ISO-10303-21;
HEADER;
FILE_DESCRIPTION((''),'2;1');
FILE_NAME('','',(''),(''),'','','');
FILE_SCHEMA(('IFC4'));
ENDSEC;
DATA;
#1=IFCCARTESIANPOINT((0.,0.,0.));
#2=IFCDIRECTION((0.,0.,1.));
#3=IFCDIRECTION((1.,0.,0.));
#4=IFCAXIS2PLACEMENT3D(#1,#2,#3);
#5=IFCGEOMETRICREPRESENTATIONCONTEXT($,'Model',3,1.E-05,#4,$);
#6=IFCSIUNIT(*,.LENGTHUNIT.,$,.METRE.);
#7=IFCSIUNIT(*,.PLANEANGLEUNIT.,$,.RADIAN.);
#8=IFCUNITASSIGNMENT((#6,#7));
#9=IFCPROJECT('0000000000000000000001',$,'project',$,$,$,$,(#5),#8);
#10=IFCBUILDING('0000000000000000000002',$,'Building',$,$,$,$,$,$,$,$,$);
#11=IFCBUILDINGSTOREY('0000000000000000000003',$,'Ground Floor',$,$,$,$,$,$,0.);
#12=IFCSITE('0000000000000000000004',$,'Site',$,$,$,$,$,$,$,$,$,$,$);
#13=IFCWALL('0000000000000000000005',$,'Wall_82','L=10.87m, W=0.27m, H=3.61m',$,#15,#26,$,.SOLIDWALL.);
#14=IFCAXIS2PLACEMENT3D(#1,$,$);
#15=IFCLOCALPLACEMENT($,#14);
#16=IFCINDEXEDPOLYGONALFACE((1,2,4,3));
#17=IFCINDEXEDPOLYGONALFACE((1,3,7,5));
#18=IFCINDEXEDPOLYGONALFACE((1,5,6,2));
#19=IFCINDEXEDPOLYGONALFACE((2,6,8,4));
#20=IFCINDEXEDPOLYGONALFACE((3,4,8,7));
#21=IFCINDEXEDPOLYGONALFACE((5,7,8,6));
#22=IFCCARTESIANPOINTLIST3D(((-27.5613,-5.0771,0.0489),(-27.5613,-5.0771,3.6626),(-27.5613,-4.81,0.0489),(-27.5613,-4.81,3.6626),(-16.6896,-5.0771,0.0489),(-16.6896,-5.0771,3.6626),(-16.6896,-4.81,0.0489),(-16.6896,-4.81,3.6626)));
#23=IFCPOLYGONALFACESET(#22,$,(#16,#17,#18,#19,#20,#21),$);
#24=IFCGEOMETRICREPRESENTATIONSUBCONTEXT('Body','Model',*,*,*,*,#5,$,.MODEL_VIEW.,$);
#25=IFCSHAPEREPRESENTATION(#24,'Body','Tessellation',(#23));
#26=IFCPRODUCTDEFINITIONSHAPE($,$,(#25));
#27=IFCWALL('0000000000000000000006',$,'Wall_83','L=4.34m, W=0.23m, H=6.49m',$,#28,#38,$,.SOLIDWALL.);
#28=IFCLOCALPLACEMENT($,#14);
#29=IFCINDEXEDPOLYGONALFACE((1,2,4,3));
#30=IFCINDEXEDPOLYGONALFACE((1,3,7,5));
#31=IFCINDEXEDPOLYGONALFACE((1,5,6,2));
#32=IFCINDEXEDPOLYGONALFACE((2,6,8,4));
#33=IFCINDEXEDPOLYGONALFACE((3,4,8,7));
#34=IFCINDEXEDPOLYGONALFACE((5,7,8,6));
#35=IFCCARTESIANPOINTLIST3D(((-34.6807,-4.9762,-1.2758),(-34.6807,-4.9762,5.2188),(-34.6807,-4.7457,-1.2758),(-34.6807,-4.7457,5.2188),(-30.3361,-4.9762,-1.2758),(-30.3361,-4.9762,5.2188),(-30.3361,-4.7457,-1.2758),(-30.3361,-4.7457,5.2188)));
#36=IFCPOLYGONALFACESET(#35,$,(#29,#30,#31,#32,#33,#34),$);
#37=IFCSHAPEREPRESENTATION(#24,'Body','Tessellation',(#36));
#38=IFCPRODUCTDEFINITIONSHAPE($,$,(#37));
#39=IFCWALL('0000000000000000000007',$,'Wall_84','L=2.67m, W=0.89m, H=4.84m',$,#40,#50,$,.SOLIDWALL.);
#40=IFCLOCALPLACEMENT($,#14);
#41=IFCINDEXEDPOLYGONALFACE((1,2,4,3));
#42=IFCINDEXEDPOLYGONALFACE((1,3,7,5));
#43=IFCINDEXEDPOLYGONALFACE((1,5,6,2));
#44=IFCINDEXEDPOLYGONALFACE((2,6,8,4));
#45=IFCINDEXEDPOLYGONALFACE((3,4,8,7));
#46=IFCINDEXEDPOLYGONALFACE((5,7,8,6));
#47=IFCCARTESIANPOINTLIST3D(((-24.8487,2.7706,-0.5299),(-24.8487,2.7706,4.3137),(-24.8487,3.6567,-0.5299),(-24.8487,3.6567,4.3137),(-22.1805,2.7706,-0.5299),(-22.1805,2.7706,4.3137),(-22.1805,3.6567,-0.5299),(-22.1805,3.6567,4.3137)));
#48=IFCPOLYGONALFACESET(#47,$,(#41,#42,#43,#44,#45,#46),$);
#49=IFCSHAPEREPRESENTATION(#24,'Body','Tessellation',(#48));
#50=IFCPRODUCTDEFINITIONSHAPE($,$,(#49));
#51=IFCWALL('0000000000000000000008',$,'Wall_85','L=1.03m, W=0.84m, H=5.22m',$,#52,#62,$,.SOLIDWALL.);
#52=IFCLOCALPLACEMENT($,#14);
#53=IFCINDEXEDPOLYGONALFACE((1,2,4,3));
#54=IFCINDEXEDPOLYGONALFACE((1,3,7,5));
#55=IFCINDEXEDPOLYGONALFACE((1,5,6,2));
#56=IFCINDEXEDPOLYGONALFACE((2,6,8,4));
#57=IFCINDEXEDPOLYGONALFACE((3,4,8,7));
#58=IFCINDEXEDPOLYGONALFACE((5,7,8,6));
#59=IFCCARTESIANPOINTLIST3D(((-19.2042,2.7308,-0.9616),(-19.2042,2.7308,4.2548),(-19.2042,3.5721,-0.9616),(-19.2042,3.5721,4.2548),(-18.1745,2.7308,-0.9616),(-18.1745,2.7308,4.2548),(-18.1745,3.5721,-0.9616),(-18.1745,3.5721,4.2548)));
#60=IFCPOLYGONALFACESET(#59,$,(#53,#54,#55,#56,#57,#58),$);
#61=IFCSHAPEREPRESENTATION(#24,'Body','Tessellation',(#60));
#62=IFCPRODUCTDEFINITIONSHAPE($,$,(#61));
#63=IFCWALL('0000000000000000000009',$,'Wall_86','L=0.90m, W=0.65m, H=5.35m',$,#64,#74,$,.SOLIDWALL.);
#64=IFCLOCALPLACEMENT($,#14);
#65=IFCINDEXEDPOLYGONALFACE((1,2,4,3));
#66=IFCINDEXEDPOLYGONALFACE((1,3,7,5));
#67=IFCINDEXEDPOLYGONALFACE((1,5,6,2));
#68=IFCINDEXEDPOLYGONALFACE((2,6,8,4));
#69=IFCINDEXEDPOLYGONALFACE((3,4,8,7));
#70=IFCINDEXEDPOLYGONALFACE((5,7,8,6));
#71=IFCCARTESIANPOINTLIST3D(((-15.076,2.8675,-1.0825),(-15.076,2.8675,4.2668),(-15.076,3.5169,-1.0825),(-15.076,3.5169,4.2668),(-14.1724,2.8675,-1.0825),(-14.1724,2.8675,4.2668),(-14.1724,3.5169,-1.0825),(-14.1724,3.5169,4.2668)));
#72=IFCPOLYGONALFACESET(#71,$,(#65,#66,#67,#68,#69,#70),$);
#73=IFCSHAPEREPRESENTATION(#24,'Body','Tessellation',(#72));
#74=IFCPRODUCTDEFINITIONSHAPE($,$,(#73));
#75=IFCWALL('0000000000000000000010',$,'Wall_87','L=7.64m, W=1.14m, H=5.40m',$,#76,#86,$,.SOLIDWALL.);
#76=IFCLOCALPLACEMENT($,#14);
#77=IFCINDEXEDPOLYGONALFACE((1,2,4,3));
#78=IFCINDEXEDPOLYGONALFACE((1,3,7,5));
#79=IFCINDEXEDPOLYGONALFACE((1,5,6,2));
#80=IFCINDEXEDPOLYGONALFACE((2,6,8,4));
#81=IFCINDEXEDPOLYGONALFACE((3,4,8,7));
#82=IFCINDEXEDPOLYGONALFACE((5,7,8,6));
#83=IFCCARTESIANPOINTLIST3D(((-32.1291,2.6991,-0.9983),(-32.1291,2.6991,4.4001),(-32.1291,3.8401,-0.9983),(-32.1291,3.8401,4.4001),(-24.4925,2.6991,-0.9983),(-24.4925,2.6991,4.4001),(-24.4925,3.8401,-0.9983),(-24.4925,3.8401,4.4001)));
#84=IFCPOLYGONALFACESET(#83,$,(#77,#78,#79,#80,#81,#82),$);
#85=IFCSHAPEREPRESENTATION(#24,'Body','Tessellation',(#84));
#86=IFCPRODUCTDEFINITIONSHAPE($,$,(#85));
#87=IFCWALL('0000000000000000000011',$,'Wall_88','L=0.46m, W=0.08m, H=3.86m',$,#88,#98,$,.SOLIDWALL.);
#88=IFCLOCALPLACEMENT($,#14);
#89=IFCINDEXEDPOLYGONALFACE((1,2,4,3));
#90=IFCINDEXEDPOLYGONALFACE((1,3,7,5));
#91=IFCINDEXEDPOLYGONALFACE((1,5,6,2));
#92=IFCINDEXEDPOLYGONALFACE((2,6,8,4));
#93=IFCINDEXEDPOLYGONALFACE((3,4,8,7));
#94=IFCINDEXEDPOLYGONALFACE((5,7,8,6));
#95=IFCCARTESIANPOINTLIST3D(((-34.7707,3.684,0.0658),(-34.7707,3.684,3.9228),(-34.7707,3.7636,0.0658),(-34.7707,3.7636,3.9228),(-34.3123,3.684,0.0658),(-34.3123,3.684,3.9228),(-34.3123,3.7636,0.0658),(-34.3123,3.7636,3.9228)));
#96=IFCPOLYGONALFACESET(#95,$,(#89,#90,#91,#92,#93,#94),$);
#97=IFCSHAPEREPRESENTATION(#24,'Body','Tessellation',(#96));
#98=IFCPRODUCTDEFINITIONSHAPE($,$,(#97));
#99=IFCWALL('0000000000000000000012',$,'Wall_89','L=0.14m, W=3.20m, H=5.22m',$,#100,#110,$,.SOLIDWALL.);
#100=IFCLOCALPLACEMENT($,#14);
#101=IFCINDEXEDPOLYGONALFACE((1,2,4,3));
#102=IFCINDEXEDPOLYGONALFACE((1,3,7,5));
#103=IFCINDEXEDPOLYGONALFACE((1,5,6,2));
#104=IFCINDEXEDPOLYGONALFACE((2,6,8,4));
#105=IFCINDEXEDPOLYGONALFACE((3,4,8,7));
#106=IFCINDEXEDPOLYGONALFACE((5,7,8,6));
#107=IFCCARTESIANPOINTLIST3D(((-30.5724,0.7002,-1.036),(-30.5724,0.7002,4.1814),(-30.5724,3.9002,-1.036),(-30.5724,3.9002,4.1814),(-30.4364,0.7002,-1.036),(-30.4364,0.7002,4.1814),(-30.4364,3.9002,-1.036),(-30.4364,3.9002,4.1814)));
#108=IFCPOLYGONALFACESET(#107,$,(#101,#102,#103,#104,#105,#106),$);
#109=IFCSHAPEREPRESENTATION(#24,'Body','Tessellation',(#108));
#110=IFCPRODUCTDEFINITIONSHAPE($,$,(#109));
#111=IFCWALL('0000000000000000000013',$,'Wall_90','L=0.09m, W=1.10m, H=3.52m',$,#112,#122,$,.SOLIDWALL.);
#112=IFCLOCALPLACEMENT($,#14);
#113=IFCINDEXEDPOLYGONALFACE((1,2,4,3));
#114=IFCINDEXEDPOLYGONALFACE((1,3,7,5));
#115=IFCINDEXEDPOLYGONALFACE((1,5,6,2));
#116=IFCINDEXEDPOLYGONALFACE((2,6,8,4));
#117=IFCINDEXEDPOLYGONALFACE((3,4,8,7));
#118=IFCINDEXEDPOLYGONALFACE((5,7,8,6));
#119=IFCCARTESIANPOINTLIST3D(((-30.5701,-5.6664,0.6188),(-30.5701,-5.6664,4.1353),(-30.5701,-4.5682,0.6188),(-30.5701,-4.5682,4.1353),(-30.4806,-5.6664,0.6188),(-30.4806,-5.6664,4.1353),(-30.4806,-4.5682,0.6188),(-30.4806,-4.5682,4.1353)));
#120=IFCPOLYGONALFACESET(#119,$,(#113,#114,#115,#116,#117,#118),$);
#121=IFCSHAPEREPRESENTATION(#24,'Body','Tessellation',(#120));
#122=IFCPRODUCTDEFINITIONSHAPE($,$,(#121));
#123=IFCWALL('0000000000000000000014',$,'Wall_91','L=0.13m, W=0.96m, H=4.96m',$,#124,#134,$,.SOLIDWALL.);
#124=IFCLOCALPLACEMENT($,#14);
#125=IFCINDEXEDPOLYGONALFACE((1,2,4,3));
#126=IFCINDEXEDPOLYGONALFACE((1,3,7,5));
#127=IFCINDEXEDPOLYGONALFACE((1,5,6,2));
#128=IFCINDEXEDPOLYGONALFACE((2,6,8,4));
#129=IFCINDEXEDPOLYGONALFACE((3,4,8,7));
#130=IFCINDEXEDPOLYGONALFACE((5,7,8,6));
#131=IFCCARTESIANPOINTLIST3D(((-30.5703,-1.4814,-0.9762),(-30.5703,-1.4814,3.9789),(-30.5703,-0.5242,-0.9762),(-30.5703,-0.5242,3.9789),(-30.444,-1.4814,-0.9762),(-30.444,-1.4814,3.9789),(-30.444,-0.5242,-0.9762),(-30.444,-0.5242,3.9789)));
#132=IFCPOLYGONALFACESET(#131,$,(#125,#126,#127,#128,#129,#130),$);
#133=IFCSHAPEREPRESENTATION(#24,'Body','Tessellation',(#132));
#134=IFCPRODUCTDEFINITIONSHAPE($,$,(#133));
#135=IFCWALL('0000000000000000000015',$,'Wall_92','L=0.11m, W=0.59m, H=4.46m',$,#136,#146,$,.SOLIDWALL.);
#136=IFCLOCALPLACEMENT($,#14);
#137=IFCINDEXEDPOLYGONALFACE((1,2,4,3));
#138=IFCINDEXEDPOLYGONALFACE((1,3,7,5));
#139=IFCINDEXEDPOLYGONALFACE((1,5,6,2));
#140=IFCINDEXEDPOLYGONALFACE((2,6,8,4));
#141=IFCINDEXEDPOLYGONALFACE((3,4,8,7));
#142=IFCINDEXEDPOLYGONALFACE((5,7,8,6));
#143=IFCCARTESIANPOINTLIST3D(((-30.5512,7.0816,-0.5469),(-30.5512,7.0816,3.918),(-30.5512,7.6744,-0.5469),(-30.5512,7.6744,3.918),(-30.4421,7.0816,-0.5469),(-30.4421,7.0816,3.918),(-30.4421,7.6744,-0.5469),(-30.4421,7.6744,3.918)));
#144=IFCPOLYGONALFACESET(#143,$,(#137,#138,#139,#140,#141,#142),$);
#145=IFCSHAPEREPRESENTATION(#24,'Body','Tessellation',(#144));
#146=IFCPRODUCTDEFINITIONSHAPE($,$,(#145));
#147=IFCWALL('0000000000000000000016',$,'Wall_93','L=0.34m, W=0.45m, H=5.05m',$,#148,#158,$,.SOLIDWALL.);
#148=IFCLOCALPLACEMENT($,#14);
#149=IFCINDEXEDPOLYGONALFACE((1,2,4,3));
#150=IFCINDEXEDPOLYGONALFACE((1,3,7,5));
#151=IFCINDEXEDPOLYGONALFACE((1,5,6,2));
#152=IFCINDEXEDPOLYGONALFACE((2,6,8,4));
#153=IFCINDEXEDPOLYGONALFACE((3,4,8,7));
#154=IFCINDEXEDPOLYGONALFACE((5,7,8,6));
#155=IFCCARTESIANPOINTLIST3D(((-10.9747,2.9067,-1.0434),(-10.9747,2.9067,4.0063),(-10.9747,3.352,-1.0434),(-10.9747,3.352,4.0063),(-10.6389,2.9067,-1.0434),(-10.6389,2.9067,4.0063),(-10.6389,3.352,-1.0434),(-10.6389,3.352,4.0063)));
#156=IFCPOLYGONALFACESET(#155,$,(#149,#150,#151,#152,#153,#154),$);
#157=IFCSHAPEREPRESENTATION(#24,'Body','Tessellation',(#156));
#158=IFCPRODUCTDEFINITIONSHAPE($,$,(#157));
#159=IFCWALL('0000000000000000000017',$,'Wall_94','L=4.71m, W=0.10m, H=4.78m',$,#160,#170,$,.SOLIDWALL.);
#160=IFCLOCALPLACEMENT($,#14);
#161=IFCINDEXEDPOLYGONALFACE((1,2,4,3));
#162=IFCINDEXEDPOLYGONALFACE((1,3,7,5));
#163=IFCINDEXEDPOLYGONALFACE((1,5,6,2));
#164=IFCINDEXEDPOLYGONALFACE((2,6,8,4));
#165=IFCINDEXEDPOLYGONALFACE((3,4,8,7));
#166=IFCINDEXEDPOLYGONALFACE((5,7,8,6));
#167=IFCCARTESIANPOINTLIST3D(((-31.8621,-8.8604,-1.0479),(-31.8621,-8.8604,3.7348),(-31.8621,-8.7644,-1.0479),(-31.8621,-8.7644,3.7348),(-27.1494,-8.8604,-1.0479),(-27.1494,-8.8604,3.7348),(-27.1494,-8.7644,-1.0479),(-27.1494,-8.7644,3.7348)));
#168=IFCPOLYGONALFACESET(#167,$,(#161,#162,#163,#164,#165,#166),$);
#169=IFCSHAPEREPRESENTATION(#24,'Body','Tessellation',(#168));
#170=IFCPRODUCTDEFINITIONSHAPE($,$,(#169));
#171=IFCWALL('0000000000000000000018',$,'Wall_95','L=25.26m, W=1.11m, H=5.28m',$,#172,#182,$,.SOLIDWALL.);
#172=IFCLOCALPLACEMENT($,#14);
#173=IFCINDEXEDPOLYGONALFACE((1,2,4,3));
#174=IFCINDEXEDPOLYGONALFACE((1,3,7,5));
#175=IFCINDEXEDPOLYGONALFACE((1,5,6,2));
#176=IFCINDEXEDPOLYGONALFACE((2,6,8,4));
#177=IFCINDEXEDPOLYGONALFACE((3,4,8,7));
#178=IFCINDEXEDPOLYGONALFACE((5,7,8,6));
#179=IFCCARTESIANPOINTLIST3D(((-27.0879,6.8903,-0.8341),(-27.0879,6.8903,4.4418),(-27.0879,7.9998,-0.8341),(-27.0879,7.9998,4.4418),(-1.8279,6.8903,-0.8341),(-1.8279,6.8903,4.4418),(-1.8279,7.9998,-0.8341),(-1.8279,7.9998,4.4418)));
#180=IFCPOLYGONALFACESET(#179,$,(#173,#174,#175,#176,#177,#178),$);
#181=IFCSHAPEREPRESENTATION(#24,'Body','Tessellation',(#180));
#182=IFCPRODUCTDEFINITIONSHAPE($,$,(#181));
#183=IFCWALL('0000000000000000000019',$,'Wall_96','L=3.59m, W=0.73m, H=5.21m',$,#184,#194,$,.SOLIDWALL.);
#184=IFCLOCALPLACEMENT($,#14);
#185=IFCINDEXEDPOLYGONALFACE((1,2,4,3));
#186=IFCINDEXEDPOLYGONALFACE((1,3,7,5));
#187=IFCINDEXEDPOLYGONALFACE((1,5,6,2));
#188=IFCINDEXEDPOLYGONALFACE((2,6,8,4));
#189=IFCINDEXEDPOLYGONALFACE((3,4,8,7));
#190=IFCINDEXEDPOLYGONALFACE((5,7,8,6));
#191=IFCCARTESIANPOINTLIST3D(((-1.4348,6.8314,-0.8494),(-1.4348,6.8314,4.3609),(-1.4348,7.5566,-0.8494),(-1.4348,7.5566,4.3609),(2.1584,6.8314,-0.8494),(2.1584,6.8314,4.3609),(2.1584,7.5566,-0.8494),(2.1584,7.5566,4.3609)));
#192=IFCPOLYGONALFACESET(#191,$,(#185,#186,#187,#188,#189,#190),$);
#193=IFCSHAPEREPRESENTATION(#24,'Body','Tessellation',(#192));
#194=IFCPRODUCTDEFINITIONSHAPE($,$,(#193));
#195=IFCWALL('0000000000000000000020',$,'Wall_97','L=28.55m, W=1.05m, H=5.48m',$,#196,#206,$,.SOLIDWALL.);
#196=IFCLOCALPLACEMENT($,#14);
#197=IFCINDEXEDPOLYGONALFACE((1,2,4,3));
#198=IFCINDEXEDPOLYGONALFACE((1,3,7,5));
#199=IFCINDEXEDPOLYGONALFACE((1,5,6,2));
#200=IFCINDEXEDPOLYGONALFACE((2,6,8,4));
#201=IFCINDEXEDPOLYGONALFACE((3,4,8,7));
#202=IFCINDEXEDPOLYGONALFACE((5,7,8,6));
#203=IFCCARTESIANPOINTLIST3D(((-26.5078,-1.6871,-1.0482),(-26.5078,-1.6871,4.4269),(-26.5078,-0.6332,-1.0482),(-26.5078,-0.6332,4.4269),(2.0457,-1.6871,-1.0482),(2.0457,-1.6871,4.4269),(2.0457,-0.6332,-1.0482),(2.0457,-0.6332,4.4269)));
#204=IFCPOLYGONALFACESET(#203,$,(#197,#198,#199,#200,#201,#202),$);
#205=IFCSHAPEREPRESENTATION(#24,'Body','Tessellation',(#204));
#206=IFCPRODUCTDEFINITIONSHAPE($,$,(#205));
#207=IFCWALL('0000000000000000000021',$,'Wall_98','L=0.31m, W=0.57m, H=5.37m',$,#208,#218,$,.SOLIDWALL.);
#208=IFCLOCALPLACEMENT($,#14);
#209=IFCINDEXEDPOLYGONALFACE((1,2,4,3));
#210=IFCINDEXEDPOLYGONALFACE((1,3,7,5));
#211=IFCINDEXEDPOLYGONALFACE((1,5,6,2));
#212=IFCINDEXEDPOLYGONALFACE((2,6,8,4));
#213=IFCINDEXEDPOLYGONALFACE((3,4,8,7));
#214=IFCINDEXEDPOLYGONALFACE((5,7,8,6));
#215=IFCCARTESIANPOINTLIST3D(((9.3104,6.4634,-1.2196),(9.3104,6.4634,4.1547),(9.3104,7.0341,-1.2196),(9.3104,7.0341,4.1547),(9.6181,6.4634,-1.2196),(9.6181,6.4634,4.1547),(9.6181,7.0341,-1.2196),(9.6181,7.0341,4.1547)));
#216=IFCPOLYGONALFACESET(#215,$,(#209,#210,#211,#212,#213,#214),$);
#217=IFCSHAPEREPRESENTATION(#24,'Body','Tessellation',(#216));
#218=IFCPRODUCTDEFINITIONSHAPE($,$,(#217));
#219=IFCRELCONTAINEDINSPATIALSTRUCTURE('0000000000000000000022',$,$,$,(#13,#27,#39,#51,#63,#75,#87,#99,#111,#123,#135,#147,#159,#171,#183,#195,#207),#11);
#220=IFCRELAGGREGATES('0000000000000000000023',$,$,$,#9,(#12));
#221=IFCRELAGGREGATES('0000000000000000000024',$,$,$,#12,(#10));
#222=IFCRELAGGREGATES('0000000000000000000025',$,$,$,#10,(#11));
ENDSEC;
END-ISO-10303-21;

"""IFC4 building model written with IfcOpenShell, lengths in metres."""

from ifc_helpers import new_model, si_unit, frame, origin_with_axes, origin_2d, context, subcontext, project, spatial, rectangle, extrude, element, save


model = new_model("IFC4")

# Units and contexts
model_context = context("Model", 3, precision=1e-05, world=origin_with_axes())
body_context = subcontext(model_context, "Body", "Model", "MODEL_VIEW")
ifc_project = project(units=[si_unit("LENGTHUNIT", "METRE"), si_unit("PLANEANGLEUNIT", "RADIAN")], contexts=[model_context])

# Site, building, storey
site = spatial("IfcSite", under=ifc_project, Name="Site")
building = spatial("IfcBuilding", under=site, Name="Building")
storey = spatial("IfcBuildingStorey", under=building, Name="Ground Floor", Elevation=0.0)

# Walls
element("IfcWall", 1, inside=storey, Name="Wall_82", Description="L=10.87m, W=0.27m, H=3.61m", PredefinedType="SOLIDWALL", context=body_context, shape_type="SweptSolid", body=[
    extrude(rectangle(XDim=10.8717, YDim=0.267, at=origin_2d()), frame((-22.1254, -4.9436, 0.0489), z_axis=(0.0, 0.0, 1.0), x_axis=(1.0, 0.0, 0.0)), (0.0, 0.0, 1.0), 3.6137),
])
element("IfcWall", 2, inside=storey, Name="Wall_83", Description="L=4.34m, W=0.23m, H=6.49m", PredefinedType="SOLIDWALL", context=body_context, shape_type="SweptSolid", body=[
    extrude(rectangle(XDim=4.3446, YDim=0.2305, at=origin_2d()), frame((-32.5084, -4.861, -1.2758), z_axis=(0.0, 0.0, 1.0), x_axis=(1.0, 0.0, 0.0)), (0.0, 0.0, 1.0), 6.4946),
])
element("IfcWall", 3, inside=storey, Name="Wall_84", Description="L=2.67m, W=0.89m, H=4.84m", PredefinedType="SOLIDWALL", context=body_context, shape_type="SweptSolid", body=[
    extrude(rectangle(XDim=2.6682, YDim=0.8861, at=origin_2d()), frame((-23.5146, 3.2136, -0.5299), z_axis=(0.0, 0.0, 1.0), x_axis=(1.0, 0.0, 0.0)), (0.0, 0.0, 1.0), 4.8436),
])
element("IfcWall", 4, inside=storey, Name="Wall_85", Description="L=1.03m, W=0.84m, H=5.22m", PredefinedType="SOLIDWALL", context=body_context, shape_type="SweptSolid", body=[
    extrude(rectangle(XDim=1.0297, YDim=0.8412, at=origin_2d()), frame((-18.6894, 3.1514, -0.9616), z_axis=(0.0, 0.0, 1.0), x_axis=(1.0, 0.0, 0.0)), (0.0, 0.0, 1.0), 5.2164),
])
element("IfcWall", 5, inside=storey, Name="Wall_86", Description="L=0.90m, W=0.65m, H=5.35m", PredefinedType="SOLIDWALL", context=body_context, shape_type="SweptSolid", body=[
    extrude(rectangle(XDim=0.9035, YDim=0.6494, at=origin_2d()), frame((-14.6242, 3.1922, -1.0825), z_axis=(0.0, 0.0, 1.0), x_axis=(1.0, 0.0, 0.0)), (0.0, 0.0, 1.0), 5.3493),
])
element("IfcWall", 6, inside=storey, Name="Wall_87", Description="L=7.64m, W=1.14m, H=5.40m", PredefinedType="SOLIDWALL", context=body_context, shape_type="SweptSolid", body=[
    extrude(rectangle(XDim=7.6367, YDim=1.1411, at=origin_2d()), frame((-28.3108, 3.2696, -0.9983), z_axis=(0.0, 0.0, 1.0), x_axis=(1.0, 0.0, 0.0)), (0.0, 0.0, 1.0), 5.3984),
])
element("IfcWall", 7, inside=storey, Name="Wall_88", Description="L=0.46m, W=0.08m, H=3.86m", PredefinedType="SOLIDWALL", context=body_context, shape_type="SweptSolid", body=[
    extrude(rectangle(XDim=0.4584, YDim=0.0796, at=origin_2d()), frame((-34.5415, 3.7238, 0.0658), z_axis=(0.0, 0.0, 1.0), x_axis=(1.0, 0.0, 0.0)), (0.0, 0.0, 1.0), 3.857),
])
element("IfcWall", 8, inside=storey, Name="Wall_89", Description="L=0.14m, W=3.20m, H=5.22m", PredefinedType="SOLIDWALL", context=body_context, shape_type="SweptSolid", body=[
    extrude(rectangle(XDim=0.136, YDim=3.2, at=origin_2d()), frame((-30.5044, 2.3002, -1.036), z_axis=(0.0, 0.0, 1.0), x_axis=(1.0, 0.0, 0.0)), (0.0, 0.0, 1.0), 5.2174),
])
element("IfcWall", 9, inside=storey, Name="Wall_90", Description="L=0.09m, W=1.10m, H=3.52m", PredefinedType="SOLIDWALL", context=body_context, shape_type="SweptSolid", body=[
    extrude(rectangle(XDim=0.0895, YDim=1.0983, at=origin_2d()), frame((-30.5254, -5.1173, 0.6188), z_axis=(0.0, 0.0, 1.0), x_axis=(1.0, 0.0, 0.0)), (0.0, 0.0, 1.0), 3.5166),
])
element("IfcWall", 10, inside=storey, Name="Wall_91", Description="L=0.13m, W=0.96m, H=4.96m", PredefinedType="SOLIDWALL", context=body_context, shape_type="SweptSolid", body=[
    extrude(rectangle(XDim=0.1263, YDim=0.9571, at=origin_2d()), frame((-30.5071, -1.0028, -0.9762), z_axis=(0.0, 0.0, 1.0), x_axis=(1.0, 0.0, 0.0)), (0.0, 0.0, 1.0), 4.9551),
])
element("IfcWall", 11, inside=storey, Name="Wall_92", Description="L=0.11m, W=0.59m, H=4.46m", PredefinedType="SOLIDWALL", context=body_context, shape_type="SweptSolid", body=[
    extrude(rectangle(XDim=0.1091, YDim=0.5928, at=origin_2d()), frame((-30.4967, 7.378, -0.5469), z_axis=(0.0, 0.0, 1.0), x_axis=(1.0, 0.0, 0.0)), (0.0, 0.0, 1.0), 4.4649),
])
element("IfcWall", 12, inside=storey, Name="Wall_93", Description="L=0.34m, W=0.45m, H=5.05m", PredefinedType="SOLIDWALL", context=body_context, shape_type="SweptSolid", body=[
    extrude(rectangle(XDim=0.3358, YDim=0.4454, at=origin_2d()), frame((-10.8068, 3.1293, -1.0434), z_axis=(0.0, 0.0, 1.0), x_axis=(1.0, 0.0, 0.0)), (0.0, 0.0, 1.0), 5.0497),
])
element("IfcWall", 13, inside=storey, Name="Wall_94", Description="L=4.71m, W=0.10m, H=4.78m", PredefinedType="SOLIDWALL", context=body_context, shape_type="SweptSolid", body=[
    extrude(rectangle(XDim=4.7127, YDim=0.0959, at=origin_2d()), frame((-29.5058, -8.8124, -1.0479), z_axis=(0.0, 0.0, 1.0), x_axis=(1.0, 0.0, 0.0)), (0.0, 0.0, 1.0), 4.7827),
])
element("IfcWall", 14, inside=storey, Name="Wall_95", Description="L=25.26m, W=1.11m, H=5.28m", PredefinedType="SOLIDWALL", context=body_context, shape_type="SweptSolid", body=[
    extrude(rectangle(XDim=25.26, YDim=1.1095, at=origin_2d()), frame((-14.4579, 7.4451, -0.8341), z_axis=(0.0, 0.0, 1.0), x_axis=(1.0, 0.0, 0.0)), (0.0, 0.0, 1.0), 5.276),
])
element("IfcWall", 15, inside=storey, Name="Wall_96", Description="L=3.59m, W=0.73m, H=5.21m", PredefinedType="SOLIDWALL", context=body_context, shape_type="SweptSolid", body=[
    extrude(rectangle(XDim=3.5931, YDim=0.7253, at=origin_2d()), frame((0.3618, 7.194, -0.8494), z_axis=(0.0, 0.0, 1.0), x_axis=(1.0, 0.0, 0.0)), (0.0, 0.0, 1.0), 5.2103),
])
element("IfcWall", 16, inside=storey, Name="Wall_97", Description="L=28.55m, W=1.05m, H=5.48m", PredefinedType="SOLIDWALL", context=body_context, shape_type="SweptSolid", body=[
    extrude(rectangle(XDim=28.5534, YDim=1.0539, at=origin_2d()), frame((-12.231, -1.1601, -1.0482), z_axis=(0.0, 0.0, 1.0), x_axis=(1.0, 0.0, 0.0)), (0.0, 0.0, 1.0), 5.4752),
])
element("IfcWall", 17, inside=storey, Name="Wall_98", Description="L=0.31m, W=0.57m, H=5.37m", PredefinedType="SOLIDWALL", context=body_context, shape_type="SweptSolid", body=[
    extrude(rectangle(XDim=0.3077, YDim=0.5707, at=origin_2d()), frame((9.4642, 6.7487, -1.2196), z_axis=(0.0, 0.0, 1.0), x_axis=(1.0, 0.0, 0.0)), (0.0, 0.0, 1.0), 5.3743),
])

save(model, "model.ifc")
